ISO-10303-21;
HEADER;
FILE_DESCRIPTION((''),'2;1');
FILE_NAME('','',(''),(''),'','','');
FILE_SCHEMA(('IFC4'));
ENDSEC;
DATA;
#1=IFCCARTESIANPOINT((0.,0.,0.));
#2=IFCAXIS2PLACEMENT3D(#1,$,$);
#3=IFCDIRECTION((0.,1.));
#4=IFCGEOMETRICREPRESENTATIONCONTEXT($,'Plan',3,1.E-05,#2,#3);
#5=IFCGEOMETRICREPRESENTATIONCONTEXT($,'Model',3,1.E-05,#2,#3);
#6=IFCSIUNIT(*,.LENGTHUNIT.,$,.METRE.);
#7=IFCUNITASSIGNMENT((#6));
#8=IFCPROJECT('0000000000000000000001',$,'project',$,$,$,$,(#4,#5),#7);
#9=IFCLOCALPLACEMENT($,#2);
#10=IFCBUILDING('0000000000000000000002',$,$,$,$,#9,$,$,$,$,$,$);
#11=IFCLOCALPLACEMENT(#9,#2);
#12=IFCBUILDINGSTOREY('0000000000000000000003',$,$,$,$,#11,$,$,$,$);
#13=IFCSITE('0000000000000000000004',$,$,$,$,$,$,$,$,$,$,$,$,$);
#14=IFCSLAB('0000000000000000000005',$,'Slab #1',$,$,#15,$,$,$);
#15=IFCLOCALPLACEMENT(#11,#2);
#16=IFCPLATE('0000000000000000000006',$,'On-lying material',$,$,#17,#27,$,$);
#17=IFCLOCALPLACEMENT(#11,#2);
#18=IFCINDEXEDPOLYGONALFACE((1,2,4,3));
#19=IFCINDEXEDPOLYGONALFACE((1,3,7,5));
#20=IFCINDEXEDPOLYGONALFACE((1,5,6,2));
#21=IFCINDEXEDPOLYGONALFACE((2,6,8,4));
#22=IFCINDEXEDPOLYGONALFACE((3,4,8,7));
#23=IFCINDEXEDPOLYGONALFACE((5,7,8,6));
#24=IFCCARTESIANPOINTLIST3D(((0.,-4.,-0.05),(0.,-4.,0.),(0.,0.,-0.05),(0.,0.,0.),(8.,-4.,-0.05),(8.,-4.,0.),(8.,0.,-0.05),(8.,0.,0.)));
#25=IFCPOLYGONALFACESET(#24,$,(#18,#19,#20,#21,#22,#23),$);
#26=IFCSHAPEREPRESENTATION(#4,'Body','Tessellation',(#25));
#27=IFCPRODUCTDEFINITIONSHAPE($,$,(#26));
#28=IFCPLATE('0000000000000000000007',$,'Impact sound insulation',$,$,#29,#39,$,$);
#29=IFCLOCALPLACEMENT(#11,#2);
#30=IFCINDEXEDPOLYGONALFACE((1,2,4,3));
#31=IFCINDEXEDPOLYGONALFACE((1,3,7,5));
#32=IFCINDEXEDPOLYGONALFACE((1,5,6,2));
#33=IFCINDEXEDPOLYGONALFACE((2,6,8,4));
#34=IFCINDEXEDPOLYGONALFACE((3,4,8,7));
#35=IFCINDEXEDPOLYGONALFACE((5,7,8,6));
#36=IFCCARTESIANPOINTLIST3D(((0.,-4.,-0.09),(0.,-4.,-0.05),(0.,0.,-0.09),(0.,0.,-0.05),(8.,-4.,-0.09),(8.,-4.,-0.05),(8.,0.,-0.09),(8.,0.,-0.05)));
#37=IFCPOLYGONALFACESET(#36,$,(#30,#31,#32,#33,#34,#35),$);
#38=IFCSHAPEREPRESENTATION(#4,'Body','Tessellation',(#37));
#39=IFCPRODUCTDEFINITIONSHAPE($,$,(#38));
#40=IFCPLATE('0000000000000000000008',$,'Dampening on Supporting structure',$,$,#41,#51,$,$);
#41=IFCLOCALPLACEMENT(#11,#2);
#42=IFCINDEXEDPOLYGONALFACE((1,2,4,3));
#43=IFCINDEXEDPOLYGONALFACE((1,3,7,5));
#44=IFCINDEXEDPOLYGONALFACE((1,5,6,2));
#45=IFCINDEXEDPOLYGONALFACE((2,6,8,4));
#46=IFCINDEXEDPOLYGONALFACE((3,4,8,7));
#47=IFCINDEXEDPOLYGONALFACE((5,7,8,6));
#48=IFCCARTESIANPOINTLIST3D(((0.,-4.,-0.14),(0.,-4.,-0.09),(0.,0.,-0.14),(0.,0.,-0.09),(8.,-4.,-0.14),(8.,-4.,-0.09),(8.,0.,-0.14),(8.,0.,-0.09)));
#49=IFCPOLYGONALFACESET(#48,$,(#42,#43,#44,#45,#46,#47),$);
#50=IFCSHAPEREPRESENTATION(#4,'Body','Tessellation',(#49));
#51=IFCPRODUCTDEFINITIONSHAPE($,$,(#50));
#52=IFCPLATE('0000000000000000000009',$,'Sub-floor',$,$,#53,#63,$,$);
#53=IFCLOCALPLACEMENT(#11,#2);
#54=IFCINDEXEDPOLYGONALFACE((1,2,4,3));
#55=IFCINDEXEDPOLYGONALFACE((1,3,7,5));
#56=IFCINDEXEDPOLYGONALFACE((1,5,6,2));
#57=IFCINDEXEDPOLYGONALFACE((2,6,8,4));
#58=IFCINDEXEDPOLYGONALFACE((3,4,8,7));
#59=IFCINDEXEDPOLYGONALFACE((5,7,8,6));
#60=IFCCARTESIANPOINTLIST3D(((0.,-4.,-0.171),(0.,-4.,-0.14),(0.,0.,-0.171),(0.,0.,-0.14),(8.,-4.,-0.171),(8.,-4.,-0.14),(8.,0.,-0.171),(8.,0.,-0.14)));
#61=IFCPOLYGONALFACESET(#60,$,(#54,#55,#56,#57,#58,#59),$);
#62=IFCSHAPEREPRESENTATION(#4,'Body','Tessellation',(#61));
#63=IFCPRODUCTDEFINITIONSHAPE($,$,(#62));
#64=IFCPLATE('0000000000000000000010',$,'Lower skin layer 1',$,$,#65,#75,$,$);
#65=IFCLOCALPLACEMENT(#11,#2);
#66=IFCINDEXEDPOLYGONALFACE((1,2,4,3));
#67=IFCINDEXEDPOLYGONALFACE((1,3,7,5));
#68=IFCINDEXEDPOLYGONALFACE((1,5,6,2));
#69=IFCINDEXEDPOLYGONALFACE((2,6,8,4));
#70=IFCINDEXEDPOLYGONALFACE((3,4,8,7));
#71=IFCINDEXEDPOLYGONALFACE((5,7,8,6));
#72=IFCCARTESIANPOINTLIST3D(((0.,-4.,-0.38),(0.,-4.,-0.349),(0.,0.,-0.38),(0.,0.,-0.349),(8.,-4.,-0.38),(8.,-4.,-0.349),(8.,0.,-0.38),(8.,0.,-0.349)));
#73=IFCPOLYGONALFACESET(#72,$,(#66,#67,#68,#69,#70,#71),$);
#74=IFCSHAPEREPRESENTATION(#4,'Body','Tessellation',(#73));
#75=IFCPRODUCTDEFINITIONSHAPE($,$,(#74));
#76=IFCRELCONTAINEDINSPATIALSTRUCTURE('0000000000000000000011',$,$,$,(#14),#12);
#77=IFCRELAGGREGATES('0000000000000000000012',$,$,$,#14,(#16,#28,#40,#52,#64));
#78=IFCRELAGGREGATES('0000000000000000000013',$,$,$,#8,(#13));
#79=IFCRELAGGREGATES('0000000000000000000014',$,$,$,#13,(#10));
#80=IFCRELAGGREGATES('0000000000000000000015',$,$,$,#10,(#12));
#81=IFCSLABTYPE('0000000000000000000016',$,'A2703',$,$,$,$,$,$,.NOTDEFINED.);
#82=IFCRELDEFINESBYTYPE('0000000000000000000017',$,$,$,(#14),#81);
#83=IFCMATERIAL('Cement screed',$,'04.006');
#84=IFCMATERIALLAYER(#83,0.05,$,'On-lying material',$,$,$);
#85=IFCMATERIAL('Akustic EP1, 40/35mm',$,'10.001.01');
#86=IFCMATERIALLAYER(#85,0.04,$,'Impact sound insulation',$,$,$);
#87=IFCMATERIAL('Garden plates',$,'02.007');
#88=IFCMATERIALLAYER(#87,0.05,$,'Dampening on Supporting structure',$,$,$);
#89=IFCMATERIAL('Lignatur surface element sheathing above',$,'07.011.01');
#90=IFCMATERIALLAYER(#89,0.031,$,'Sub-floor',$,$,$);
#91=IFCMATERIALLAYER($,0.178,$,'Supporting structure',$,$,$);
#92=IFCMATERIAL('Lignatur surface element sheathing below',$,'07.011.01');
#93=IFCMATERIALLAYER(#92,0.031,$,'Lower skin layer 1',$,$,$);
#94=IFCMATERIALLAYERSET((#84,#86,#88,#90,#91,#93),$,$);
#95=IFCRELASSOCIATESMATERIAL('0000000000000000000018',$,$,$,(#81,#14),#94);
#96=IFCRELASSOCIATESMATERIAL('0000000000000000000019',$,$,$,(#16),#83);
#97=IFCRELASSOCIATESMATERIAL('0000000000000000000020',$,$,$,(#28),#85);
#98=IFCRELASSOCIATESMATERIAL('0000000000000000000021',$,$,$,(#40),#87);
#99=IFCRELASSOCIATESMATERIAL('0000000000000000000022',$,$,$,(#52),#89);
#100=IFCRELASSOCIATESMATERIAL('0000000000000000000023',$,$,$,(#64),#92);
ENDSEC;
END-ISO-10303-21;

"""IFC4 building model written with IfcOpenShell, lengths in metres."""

from ifc_helpers import new_model, si_unit, direction, frame, frame_2d, origin, origin_with_axes, place, context, project, spatial, rectangle, extrude, material, layer, layer_set, type_object, element, aggregate, save


model = new_model("IFC4")

# Units and contexts
plan_context = context("Plan", 3, precision=1e-05, world=origin(), true_north=direction((0.0, 1.0)))
model_context = context("Model", 3, precision=1e-05, world=origin(), true_north=direction((0.0, 1.0)))
ifc_project = project(units=[si_unit("LENGTHUNIT", "METRE")], contexts=[plan_context, model_context])

# Site, building, storey
site = spatial("IfcSite", under=ifc_project)
building_placement = place(None, origin())
building = spatial("IfcBuilding", under=site, at=building_placement)
storey_placement = place(building_placement, origin())
storey = spatial("IfcBuildingStorey", under=building, at=storey_placement)

# Slab, plates
ifc_material_1 = material(Name="Cement screed", Category="04.006")
ifc_layer_1 = layer(ifc_material_1, 0.05, Name="On-lying material")
ifc_material_2 = material(Name="Akustic EP1, 40/35mm", Category="10.001.01")
ifc_layer_2 = layer(ifc_material_2, 0.04, Name="Impact sound insulation")
ifc_material_3 = material(Name="Garden plates", Category="02.007")
ifc_layer_3 = layer(ifc_material_3, 0.05, Name="Dampening on Supporting structure")
ifc_material_4 = material(Name="Lignatur surface element sheathing above", Category="07.011.01")
ifc_layer_4 = layer(ifc_material_4, 0.031, Name="Sub-floor")
ifc_layer_5 = layer(None, 0.178, Name="Supporting structure")
ifc_material_5 = material(Name="Lignatur surface element sheathing below", Category="07.011.01")
ifc_layer_6 = layer(ifc_material_5, 0.031, Name="Lower skin layer 1")
ifc_layer_set = layer_set([ifc_layer_1, ifc_layer_2, ifc_layer_3, ifc_layer_4, ifc_layer_5, ifc_layer_6])
slab_type = type_object("IfcSlabType", Name="A2703", PredefinedType="NOTDEFINED", material=ifc_layer_set)
slab_placement = place(None, frame((0.0, 0.0, 0.0), z_axis=(0.0, 0.0, -1.0), x_axis=(1.0, 0.0, 0.0)))
slab = element("IfcSlab", 1, at=slab_placement, inside=storey, type_object=slab_type, material=ifc_layer_set, Name="Slab #1")
plate_1_placement = place(slab_placement, origin())
plate_1 = element("IfcPlate", 2, at=plate_1_placement, material=ifc_material_1, Name="On-lying material", context=plan_context, shape_type="SweptSolid", body=[
    extrude(rectangle(XDim=8.0, YDim=4.0, at=frame_2d((4.0, 2.0), x_axis=(1.0, 0.0))), origin_with_axes(), (0.0, 0.0, 1.0), 0.05),
])
plate_2_placement = place(slab_placement, origin())
plate_2 = element("IfcPlate", 3, at=plate_2_placement, material=ifc_material_2, Name="Impact sound insulation", context=plan_context, shape_type="SweptSolid", body=[
    extrude(rectangle(XDim=8.0, YDim=4.0, at=frame_2d((4.0, 2.0), x_axis=(1.0, 0.0))), frame((0.0, 0.0, 0.05), z_axis=(0.0, 0.0, 1.0), x_axis=(1.0, 0.0, 0.0)), (0.0, 0.0, 1.0), 0.04),
])
plate_3_placement = place(slab_placement, origin())
plate_3 = element("IfcPlate", 4, at=plate_3_placement, material=ifc_material_3, Name="Dampening on Supporting structure", context=plan_context, shape_type="SweptSolid", body=[
    extrude(rectangle(XDim=8.0, YDim=4.0, at=frame_2d((4.0, 2.0), x_axis=(1.0, 0.0))), frame((0.0, 0.0, 0.09), z_axis=(0.0, 0.0, 1.0), x_axis=(1.0, 0.0, 0.0)), (0.0, 0.0, 1.0), 0.05),
])
plate_4_placement = place(slab_placement, origin())
plate_4 = element("IfcPlate", 5, at=plate_4_placement, material=ifc_material_4, Name="Sub-floor", context=plan_context, shape_type="SweptSolid", body=[
    extrude(rectangle(XDim=8.0, YDim=4.0, at=frame_2d((4.0, 2.0), x_axis=(1.0, 0.0))), frame((0.0, 0.0, 0.14), z_axis=(0.0, 0.0, 1.0), x_axis=(1.0, 0.0, 0.0)), (0.0, 0.0, 1.0), 0.031),
])
plate_5_placement = place(slab_placement, origin())
plate_5 = element("IfcPlate", 6, at=plate_5_placement, material=ifc_material_5, Name="Lower skin layer 1", context=plan_context, shape_type="SweptSolid", body=[
    extrude(rectangle(XDim=8.0, YDim=4.0, at=frame_2d((4.0, 2.0), x_axis=(1.0, 0.0))), frame((0.0, 0.0, 0.349), z_axis=(0.0, 0.0, 1.0), x_axis=(1.0, 0.0, 0.0)), (0.0, 0.0, 1.0), 0.031),
])
aggregate(slab, [plate_1, plate_2, plate_3, plate_4, plate_5])

save(model, "model.ifc")
